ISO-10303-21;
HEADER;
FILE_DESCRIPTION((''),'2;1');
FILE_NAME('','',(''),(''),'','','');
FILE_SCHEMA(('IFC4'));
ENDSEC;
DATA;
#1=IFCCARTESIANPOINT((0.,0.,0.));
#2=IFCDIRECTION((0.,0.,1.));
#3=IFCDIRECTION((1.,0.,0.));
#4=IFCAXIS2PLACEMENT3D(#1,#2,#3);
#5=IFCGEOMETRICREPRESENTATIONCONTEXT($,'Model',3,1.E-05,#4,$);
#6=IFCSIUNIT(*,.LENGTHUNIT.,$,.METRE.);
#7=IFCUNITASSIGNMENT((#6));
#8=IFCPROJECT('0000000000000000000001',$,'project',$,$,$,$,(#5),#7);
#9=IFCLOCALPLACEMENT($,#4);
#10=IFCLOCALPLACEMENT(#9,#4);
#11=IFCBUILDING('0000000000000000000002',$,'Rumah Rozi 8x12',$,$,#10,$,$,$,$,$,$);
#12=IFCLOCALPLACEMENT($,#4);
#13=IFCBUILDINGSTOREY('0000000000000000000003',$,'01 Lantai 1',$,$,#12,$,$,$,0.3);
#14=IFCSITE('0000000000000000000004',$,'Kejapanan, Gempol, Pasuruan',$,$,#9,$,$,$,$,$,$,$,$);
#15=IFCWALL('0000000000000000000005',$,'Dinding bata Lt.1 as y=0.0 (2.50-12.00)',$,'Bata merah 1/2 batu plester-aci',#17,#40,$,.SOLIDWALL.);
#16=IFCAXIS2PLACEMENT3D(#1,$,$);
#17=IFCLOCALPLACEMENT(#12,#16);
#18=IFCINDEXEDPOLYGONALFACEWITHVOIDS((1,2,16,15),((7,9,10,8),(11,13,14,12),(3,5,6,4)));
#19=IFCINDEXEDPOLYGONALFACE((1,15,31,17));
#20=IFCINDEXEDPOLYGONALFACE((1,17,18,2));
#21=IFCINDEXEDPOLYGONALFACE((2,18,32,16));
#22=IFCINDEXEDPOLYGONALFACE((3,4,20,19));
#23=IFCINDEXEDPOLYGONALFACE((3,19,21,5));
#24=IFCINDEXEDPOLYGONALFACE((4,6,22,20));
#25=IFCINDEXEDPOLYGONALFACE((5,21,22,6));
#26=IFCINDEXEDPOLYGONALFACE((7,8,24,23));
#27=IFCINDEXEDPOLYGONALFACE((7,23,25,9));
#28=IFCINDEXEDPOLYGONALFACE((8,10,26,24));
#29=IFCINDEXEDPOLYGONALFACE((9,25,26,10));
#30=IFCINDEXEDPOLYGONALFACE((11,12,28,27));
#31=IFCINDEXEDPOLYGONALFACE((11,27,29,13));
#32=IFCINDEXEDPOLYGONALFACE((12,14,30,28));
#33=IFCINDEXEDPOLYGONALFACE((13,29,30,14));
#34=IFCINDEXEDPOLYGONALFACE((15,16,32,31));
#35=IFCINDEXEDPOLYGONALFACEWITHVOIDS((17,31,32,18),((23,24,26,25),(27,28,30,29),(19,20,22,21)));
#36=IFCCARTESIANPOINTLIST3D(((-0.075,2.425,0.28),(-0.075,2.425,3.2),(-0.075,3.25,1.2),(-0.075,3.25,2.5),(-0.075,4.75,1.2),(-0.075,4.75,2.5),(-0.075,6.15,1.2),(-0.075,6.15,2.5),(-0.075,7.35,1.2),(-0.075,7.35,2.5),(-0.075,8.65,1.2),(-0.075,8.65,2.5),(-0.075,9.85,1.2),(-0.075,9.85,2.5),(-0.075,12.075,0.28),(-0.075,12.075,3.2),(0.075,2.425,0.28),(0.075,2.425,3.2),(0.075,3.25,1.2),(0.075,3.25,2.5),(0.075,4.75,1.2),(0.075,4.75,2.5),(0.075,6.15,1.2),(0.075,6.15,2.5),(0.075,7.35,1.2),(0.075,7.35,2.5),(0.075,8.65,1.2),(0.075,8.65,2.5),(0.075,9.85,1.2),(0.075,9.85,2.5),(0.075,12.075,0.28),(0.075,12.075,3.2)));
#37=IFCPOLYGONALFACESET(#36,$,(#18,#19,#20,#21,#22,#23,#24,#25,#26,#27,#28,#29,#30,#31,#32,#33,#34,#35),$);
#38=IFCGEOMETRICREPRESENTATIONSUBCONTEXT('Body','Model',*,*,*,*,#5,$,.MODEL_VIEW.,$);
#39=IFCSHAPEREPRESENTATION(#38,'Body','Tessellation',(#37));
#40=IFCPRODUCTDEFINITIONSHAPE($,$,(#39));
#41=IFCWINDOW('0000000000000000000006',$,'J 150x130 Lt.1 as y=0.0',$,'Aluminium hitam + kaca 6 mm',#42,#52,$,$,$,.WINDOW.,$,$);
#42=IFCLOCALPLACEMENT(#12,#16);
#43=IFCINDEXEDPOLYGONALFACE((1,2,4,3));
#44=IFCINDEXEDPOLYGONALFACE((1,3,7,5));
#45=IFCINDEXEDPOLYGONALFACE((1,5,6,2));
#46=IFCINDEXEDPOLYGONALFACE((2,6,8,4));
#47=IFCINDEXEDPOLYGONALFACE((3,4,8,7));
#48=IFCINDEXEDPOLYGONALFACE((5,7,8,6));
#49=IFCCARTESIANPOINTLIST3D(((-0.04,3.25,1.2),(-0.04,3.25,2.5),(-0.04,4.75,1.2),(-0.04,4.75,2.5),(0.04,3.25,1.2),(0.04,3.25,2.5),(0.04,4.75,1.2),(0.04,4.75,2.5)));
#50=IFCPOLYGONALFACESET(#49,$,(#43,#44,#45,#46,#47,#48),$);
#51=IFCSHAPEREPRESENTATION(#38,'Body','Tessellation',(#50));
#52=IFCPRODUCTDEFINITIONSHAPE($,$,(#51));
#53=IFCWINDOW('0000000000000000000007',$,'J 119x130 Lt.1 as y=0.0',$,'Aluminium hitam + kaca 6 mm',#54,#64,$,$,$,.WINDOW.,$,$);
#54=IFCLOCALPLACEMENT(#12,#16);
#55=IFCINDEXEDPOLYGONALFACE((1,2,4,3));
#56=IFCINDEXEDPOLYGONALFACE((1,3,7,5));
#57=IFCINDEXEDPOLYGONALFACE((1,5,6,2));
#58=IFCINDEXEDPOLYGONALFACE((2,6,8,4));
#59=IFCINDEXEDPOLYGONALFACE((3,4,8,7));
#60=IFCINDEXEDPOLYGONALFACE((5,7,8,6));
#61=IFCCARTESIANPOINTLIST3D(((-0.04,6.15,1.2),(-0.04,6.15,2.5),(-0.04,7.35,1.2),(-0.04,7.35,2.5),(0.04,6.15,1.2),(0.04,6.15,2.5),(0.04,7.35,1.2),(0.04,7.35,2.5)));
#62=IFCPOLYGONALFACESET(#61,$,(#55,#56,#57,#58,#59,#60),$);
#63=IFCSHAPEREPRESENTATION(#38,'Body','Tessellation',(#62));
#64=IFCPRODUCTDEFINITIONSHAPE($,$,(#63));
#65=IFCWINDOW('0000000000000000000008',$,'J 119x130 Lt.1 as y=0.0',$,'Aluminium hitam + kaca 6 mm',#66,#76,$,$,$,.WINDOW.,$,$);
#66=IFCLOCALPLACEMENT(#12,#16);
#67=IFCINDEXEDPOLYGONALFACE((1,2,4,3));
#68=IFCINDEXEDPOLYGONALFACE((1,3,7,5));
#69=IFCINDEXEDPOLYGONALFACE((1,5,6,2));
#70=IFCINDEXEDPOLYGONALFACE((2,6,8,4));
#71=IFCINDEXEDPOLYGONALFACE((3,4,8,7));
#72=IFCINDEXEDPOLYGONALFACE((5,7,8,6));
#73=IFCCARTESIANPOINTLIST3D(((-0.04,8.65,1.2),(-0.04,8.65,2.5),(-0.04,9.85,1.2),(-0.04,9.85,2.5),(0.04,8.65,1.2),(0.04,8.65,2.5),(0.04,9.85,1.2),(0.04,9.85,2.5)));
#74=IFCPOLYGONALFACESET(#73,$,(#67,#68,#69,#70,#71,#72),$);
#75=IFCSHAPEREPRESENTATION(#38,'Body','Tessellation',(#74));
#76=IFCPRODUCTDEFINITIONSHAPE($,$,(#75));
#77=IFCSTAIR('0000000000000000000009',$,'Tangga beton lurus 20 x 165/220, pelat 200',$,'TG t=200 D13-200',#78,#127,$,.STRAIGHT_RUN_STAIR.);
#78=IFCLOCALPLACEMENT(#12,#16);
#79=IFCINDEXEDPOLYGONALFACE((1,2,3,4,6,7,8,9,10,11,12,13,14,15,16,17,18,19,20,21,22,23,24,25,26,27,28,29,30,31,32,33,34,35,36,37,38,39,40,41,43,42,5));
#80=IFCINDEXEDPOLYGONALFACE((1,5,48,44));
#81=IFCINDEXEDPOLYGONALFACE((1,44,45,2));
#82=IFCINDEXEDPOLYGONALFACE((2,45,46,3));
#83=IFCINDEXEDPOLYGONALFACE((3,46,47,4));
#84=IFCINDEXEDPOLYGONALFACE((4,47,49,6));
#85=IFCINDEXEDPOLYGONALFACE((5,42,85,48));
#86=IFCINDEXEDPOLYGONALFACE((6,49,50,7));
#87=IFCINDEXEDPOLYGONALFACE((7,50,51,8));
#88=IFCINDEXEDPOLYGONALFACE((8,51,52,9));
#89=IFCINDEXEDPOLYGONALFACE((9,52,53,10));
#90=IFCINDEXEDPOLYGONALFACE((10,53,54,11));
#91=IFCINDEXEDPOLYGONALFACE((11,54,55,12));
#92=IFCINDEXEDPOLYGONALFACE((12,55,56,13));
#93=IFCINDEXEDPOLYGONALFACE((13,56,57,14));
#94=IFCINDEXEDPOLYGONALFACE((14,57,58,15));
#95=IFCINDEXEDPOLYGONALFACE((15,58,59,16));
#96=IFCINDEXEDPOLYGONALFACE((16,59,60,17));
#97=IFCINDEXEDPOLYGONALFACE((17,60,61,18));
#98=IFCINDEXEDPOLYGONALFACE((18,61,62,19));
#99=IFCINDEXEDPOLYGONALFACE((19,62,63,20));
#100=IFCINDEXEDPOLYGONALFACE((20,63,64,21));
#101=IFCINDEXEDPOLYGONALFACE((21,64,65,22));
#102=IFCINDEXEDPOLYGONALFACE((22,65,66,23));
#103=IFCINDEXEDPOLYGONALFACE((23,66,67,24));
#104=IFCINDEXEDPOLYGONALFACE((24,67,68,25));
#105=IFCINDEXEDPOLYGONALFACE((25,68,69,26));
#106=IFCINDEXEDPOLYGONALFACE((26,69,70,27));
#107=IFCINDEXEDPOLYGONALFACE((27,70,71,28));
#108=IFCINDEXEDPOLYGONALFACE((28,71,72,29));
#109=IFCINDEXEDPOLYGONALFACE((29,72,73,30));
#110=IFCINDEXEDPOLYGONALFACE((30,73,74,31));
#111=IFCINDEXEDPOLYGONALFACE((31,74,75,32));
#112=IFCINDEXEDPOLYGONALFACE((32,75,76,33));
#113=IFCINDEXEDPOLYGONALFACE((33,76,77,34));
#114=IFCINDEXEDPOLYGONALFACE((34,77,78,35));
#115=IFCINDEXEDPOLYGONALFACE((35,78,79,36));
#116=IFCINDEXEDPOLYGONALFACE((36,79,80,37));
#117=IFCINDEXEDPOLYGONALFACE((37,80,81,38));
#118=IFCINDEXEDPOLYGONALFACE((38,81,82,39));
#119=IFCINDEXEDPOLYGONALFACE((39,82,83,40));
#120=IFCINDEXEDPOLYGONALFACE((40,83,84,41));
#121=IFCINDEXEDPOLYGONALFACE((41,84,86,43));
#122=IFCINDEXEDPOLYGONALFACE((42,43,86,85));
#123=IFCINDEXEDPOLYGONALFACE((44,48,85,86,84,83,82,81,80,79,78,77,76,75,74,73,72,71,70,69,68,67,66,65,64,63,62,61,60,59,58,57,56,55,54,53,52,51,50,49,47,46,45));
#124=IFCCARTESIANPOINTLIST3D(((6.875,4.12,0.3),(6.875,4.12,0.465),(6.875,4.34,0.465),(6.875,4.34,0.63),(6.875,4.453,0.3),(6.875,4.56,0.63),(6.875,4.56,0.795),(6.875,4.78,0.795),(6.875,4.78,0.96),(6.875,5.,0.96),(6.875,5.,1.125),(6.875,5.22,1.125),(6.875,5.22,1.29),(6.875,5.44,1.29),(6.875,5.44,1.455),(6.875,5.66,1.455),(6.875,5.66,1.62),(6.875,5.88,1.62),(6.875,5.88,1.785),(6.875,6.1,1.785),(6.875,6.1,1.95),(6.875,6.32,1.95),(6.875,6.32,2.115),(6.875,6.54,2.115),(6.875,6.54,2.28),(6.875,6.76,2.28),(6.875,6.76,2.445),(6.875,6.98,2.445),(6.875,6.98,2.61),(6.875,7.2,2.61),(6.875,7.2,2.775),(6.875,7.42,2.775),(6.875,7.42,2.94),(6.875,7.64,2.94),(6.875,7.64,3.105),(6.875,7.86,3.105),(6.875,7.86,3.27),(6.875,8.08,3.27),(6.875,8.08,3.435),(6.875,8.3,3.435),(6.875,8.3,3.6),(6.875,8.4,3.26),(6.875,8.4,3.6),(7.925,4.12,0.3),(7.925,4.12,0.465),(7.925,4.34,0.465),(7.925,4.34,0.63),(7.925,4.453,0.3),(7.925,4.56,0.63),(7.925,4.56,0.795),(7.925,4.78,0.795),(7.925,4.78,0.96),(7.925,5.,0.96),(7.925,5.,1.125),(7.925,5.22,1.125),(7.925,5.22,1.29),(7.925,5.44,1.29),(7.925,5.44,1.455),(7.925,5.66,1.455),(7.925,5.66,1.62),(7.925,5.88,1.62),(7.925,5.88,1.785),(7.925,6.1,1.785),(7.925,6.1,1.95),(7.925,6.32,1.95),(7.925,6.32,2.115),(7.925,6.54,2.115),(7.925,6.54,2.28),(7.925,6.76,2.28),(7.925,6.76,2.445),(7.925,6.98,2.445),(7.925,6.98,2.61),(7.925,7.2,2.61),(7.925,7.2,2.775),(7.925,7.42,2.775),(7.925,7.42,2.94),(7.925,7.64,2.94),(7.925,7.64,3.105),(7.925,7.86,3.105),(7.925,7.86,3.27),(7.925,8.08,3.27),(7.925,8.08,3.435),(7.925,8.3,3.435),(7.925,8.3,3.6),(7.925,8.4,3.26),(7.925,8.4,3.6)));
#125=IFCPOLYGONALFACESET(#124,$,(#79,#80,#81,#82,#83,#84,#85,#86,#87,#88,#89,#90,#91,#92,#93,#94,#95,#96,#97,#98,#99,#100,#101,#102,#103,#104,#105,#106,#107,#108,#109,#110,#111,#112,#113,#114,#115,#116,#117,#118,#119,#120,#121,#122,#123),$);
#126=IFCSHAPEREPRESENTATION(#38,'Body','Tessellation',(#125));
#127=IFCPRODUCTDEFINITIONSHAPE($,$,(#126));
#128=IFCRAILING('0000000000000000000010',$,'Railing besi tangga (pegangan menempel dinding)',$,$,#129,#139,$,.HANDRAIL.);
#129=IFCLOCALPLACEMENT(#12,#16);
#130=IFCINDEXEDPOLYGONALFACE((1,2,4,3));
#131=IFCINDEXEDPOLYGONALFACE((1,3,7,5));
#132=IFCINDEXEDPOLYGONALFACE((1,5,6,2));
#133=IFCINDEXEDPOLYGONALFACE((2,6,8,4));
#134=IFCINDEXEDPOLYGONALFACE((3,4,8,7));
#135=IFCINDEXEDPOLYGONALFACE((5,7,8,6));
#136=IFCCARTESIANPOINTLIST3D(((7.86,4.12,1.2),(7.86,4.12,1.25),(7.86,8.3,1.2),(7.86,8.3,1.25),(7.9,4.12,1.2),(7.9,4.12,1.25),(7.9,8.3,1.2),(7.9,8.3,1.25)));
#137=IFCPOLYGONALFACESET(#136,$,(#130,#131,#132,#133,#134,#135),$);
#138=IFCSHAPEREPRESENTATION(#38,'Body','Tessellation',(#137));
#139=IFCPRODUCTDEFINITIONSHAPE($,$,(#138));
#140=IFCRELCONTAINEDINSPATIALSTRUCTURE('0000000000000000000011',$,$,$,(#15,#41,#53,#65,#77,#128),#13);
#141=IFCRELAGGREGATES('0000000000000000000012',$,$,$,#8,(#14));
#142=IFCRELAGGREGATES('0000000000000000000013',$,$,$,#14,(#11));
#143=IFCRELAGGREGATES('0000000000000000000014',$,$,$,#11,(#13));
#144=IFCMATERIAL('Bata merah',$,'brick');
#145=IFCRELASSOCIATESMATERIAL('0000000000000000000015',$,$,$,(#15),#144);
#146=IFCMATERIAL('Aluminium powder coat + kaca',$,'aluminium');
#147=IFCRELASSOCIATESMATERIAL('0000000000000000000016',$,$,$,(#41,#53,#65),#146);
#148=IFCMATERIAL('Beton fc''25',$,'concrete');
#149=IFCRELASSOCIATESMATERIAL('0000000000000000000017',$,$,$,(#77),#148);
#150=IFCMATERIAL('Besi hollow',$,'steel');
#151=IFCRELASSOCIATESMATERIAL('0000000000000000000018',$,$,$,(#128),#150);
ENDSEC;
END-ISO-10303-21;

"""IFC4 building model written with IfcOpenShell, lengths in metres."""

from ifc_helpers import new_model, si_unit, frame, origin_with_axes, place, context, subcontext, project, spatial, line, indexed_curve, outline, extrude, material, element, fill, save


model = new_model("IFC4")

# Units and contexts
model_context = context("Model", 3, precision=1e-05, world=origin_with_axes())
body_context = subcontext(model_context, "Body", "Model", "MODEL_VIEW")
ifc_project = project(units=[si_unit("LENGTHUNIT", "METRE")], contexts=[model_context])

# Site, building, storey
site_placement = place(None, origin_with_axes())
site = spatial("IfcSite", under=ifc_project, at=site_placement, Name="Kejapanan, Gempol, Pasuruan")
building_placement = place(site_placement, origin_with_axes())
building = spatial("IfcBuilding", under=site, at=building_placement, Name="Rumah Rozi 8x12")
storey_placement = place(None, origin_with_axes())
storey = spatial("IfcBuildingStorey", under=building, at=storey_placement, Name="01 Lantai 1", Elevation=0.3)

# Shared definitions
ifc_material_1 = material(Name="Beton fc'25", Category="concrete")

# Wall, openings, windows
ifc_material_2 = material(Name="Bata merah", Category="brick")
wall_placement = place(storey_placement, origin_with_axes())
wall = element("IfcWall", 1, at=wall_placement, inside=storey, material=ifc_material_2, Name="Dinding bata Lt.1 as y=0.0 (2.50-12.00)", ObjectType="Bata merah 1/2 batu plester-aci", PredefinedType="SOLIDWALL", context=body_context, shape_type="SweptSolid", body=[
    extrude(outline(indexed_curve([(-0.075, 2.425), (0.075, 2.425), (0.075, 12.075), (-0.075, 12.075)], segments=[line(1, 2, 3, 4, 1)])), frame((0.0, 0.0, 0.28), z_axis=(0.0, 0.0, 1.0), x_axis=(1.0, 0.0, 0.0)), (0.0, 0.0, 1.0), 2.92),
])
opening_1_placement = place(wall_placement, origin_with_axes())
opening_1 = element("IfcOpeningElement", 2, at=opening_1_placement, cuts=wall, context=body_context, shape_type="SweptSolid", body=[
    extrude(outline(indexed_curve([(-0.085, 3.25), (0.085, 3.25), (0.085, 4.75), (-0.085, 4.75)], segments=[line(1, 2, 3, 4, 1)])), frame((0.0, 0.0, 1.2), z_axis=(0.0, 0.0, 1.0), x_axis=(1.0, 0.0, 0.0)), (0.0, 0.0, 1.0), 1.3),
])
opening_2_placement = place(wall_placement, origin_with_axes())
opening_2 = element("IfcOpeningElement", 3, at=opening_2_placement, cuts=wall, context=body_context, shape_type="SweptSolid", body=[
    extrude(outline(indexed_curve([(-0.085, 6.15), (0.085, 6.15), (0.085, 7.35), (-0.085, 7.35)], segments=[line(1, 2, 3, 4, 1)])), frame((0.0, 0.0, 1.2), z_axis=(0.0, 0.0, 1.0), x_axis=(1.0, 0.0, 0.0)), (0.0, 0.0, 1.0), 1.3),
])
opening_3_placement = place(wall_placement, origin_with_axes())
opening_3 = element("IfcOpeningElement", 4, at=opening_3_placement, cuts=wall, context=body_context, shape_type="SweptSolid", body=[
    extrude(outline(indexed_curve([(-0.085, 8.65), (0.085, 8.65), (0.085, 9.85), (-0.085, 9.85)], segments=[line(1, 2, 3, 4, 1)])), frame((0.0, 0.0, 1.2), z_axis=(0.0, 0.0, 1.0), x_axis=(1.0, 0.0, 0.0)), (0.0, 0.0, 1.0), 1.3),
])
ifc_material_3 = material(Name="Aluminium powder coat + kaca", Category="aluminium")
window_1_placement = place(storey_placement, origin_with_axes())
window_1 = element("IfcWindow", 5, at=window_1_placement, inside=storey, material=ifc_material_3, Name="J 150x130 Lt.1 as y=0.0", ObjectType="Aluminium hitam + kaca 6 mm", PredefinedType="WINDOW", context=body_context, shape_type="SweptSolid", body=[
    extrude(outline(indexed_curve([(-0.04, 3.25), (0.04, 3.25), (0.04, 4.75), (-0.04, 4.75)], segments=[line(1, 2, 3, 4, 1)])), frame((0.0, 0.0, 1.2), z_axis=(0.0, 0.0, 1.0), x_axis=(1.0, 0.0, 0.0)), (0.0, 0.0, 1.0), 1.3),
])
fill(opening_1, window_1)
window_2_placement = place(storey_placement, origin_with_axes())
window_2 = element("IfcWindow", 6, at=window_2_placement, inside=storey, material=ifc_material_3, Name="J 119x130 Lt.1 as y=0.0", ObjectType="Aluminium hitam + kaca 6 mm", PredefinedType="WINDOW", context=body_context, shape_type="SweptSolid", body=[
    extrude(outline(indexed_curve([(-0.04, 6.15), (0.04, 6.15), (0.04, 7.35), (-0.04, 7.35)], segments=[line(1, 2, 3, 4, 1)])), frame((0.0, 0.0, 1.2), z_axis=(0.0, 0.0, 1.0), x_axis=(1.0, 0.0, 0.0)), (0.0, 0.0, 1.0), 1.3),
])
fill(opening_2, window_2)
window_3_placement = place(storey_placement, origin_with_axes())
window_3 = element("IfcWindow", 7, at=window_3_placement, inside=storey, material=ifc_material_3, Name="J 119x130 Lt.1 as y=0.0", ObjectType="Aluminium hitam + kaca 6 mm", PredefinedType="WINDOW", context=body_context, shape_type="SweptSolid", body=[
    extrude(outline(indexed_curve([(-0.04, 8.65), (0.04, 8.65), (0.04, 9.85), (-0.04, 9.85)], segments=[line(1, 2, 3, 4, 1)])), frame((0.0, 0.0, 1.2), z_axis=(0.0, 0.0, 1.0), x_axis=(1.0, 0.0, 0.0)), (0.0, 0.0, 1.0), 1.3),
])
fill(opening_3, window_3)

# Stair
stair_placement = place(storey_placement, origin_with_axes())
element("IfcStair", 8, at=stair_placement, inside=storey, material=ifc_material_1, Name="Tangga beton lurus 20 x 165/220, pelat 200", ObjectType="TG t=200 D13-200", PredefinedType="STRAIGHT_RUN_STAIR", context=body_context, shape_type="SweptSolid", body=[
    extrude(outline(indexed_curve([(4.12, 0.3), (4.12, 0.465), (4.34, 0.465), (4.34, 0.63), (4.56, 0.63), (4.56, 0.795), (4.78, 0.795), (4.78, 0.96), (5.0, 0.96), (5.0, 1.125), (5.22, 1.125), (5.22, 1.29), (5.44, 1.29), (5.44, 1.455), (5.66, 1.455), (5.66, 1.62), (5.88, 1.62), (5.88, 1.785), (6.1, 1.785), (6.1, 1.95), (6.32, 1.95), (6.32, 2.115), (6.54, 2.115), (6.54, 2.28), (6.76, 2.28), (6.76, 2.445), (6.98, 2.445), (6.98, 2.61), (7.2, 2.61), (7.2, 2.775), (7.42, 2.775), (7.42, 2.94), (7.64, 2.94), (7.64, 3.105), (7.86, 3.105), (7.86, 3.27), (8.08, 3.27), (8.08, 3.435), (8.3, 3.435), (8.3, 3.6), (8.4, 3.6), (8.4, 3.26), (4.453, 0.3)], segments=[line(1, 2, 3, 4, 5, 6, 7, 8, 9, 10, 11, 12, 13, 14, 15, 16, 17, 18, 19, 20, 21, 22, 23, 24, 25, 26, 27, 28, 29, 30, 31, 32, 33, 34, 35, 36, 37, 38, 39, 40, 41, 42, 43, 1)])), frame((6.875, 0.0, 0.0), z_axis=(1.0, 0.0, 0.0), x_axis=(0.0, 1.0, 0.0)), (0.0, 0.0, 1.0), 1.05),
])

# Railing
ifc_material_4 = material(Name="Besi hollow", Category="steel")
railing_placement = place(storey_placement, origin_with_axes())
element("IfcRailing", 9, at=railing_placement, inside=storey, material=ifc_material_4, Name="Railing besi tangga (pegangan menempel dinding)", PredefinedType="HANDRAIL", context=body_context, shape_type="SweptSolid", body=[
    extrude(outline(indexed_curve([(7.86, 4.12), (7.9, 4.12), (7.9, 8.3), (7.86, 8.3)], segments=[line(1, 2, 3, 4, 1)])), frame((0.0, 0.0, 1.2), z_axis=(0.0, 0.0, 1.0), x_axis=(1.0, 0.0, 0.0)), (0.0, 0.0, 1.0), 0.05),
])

save(model, "model.ifc")
